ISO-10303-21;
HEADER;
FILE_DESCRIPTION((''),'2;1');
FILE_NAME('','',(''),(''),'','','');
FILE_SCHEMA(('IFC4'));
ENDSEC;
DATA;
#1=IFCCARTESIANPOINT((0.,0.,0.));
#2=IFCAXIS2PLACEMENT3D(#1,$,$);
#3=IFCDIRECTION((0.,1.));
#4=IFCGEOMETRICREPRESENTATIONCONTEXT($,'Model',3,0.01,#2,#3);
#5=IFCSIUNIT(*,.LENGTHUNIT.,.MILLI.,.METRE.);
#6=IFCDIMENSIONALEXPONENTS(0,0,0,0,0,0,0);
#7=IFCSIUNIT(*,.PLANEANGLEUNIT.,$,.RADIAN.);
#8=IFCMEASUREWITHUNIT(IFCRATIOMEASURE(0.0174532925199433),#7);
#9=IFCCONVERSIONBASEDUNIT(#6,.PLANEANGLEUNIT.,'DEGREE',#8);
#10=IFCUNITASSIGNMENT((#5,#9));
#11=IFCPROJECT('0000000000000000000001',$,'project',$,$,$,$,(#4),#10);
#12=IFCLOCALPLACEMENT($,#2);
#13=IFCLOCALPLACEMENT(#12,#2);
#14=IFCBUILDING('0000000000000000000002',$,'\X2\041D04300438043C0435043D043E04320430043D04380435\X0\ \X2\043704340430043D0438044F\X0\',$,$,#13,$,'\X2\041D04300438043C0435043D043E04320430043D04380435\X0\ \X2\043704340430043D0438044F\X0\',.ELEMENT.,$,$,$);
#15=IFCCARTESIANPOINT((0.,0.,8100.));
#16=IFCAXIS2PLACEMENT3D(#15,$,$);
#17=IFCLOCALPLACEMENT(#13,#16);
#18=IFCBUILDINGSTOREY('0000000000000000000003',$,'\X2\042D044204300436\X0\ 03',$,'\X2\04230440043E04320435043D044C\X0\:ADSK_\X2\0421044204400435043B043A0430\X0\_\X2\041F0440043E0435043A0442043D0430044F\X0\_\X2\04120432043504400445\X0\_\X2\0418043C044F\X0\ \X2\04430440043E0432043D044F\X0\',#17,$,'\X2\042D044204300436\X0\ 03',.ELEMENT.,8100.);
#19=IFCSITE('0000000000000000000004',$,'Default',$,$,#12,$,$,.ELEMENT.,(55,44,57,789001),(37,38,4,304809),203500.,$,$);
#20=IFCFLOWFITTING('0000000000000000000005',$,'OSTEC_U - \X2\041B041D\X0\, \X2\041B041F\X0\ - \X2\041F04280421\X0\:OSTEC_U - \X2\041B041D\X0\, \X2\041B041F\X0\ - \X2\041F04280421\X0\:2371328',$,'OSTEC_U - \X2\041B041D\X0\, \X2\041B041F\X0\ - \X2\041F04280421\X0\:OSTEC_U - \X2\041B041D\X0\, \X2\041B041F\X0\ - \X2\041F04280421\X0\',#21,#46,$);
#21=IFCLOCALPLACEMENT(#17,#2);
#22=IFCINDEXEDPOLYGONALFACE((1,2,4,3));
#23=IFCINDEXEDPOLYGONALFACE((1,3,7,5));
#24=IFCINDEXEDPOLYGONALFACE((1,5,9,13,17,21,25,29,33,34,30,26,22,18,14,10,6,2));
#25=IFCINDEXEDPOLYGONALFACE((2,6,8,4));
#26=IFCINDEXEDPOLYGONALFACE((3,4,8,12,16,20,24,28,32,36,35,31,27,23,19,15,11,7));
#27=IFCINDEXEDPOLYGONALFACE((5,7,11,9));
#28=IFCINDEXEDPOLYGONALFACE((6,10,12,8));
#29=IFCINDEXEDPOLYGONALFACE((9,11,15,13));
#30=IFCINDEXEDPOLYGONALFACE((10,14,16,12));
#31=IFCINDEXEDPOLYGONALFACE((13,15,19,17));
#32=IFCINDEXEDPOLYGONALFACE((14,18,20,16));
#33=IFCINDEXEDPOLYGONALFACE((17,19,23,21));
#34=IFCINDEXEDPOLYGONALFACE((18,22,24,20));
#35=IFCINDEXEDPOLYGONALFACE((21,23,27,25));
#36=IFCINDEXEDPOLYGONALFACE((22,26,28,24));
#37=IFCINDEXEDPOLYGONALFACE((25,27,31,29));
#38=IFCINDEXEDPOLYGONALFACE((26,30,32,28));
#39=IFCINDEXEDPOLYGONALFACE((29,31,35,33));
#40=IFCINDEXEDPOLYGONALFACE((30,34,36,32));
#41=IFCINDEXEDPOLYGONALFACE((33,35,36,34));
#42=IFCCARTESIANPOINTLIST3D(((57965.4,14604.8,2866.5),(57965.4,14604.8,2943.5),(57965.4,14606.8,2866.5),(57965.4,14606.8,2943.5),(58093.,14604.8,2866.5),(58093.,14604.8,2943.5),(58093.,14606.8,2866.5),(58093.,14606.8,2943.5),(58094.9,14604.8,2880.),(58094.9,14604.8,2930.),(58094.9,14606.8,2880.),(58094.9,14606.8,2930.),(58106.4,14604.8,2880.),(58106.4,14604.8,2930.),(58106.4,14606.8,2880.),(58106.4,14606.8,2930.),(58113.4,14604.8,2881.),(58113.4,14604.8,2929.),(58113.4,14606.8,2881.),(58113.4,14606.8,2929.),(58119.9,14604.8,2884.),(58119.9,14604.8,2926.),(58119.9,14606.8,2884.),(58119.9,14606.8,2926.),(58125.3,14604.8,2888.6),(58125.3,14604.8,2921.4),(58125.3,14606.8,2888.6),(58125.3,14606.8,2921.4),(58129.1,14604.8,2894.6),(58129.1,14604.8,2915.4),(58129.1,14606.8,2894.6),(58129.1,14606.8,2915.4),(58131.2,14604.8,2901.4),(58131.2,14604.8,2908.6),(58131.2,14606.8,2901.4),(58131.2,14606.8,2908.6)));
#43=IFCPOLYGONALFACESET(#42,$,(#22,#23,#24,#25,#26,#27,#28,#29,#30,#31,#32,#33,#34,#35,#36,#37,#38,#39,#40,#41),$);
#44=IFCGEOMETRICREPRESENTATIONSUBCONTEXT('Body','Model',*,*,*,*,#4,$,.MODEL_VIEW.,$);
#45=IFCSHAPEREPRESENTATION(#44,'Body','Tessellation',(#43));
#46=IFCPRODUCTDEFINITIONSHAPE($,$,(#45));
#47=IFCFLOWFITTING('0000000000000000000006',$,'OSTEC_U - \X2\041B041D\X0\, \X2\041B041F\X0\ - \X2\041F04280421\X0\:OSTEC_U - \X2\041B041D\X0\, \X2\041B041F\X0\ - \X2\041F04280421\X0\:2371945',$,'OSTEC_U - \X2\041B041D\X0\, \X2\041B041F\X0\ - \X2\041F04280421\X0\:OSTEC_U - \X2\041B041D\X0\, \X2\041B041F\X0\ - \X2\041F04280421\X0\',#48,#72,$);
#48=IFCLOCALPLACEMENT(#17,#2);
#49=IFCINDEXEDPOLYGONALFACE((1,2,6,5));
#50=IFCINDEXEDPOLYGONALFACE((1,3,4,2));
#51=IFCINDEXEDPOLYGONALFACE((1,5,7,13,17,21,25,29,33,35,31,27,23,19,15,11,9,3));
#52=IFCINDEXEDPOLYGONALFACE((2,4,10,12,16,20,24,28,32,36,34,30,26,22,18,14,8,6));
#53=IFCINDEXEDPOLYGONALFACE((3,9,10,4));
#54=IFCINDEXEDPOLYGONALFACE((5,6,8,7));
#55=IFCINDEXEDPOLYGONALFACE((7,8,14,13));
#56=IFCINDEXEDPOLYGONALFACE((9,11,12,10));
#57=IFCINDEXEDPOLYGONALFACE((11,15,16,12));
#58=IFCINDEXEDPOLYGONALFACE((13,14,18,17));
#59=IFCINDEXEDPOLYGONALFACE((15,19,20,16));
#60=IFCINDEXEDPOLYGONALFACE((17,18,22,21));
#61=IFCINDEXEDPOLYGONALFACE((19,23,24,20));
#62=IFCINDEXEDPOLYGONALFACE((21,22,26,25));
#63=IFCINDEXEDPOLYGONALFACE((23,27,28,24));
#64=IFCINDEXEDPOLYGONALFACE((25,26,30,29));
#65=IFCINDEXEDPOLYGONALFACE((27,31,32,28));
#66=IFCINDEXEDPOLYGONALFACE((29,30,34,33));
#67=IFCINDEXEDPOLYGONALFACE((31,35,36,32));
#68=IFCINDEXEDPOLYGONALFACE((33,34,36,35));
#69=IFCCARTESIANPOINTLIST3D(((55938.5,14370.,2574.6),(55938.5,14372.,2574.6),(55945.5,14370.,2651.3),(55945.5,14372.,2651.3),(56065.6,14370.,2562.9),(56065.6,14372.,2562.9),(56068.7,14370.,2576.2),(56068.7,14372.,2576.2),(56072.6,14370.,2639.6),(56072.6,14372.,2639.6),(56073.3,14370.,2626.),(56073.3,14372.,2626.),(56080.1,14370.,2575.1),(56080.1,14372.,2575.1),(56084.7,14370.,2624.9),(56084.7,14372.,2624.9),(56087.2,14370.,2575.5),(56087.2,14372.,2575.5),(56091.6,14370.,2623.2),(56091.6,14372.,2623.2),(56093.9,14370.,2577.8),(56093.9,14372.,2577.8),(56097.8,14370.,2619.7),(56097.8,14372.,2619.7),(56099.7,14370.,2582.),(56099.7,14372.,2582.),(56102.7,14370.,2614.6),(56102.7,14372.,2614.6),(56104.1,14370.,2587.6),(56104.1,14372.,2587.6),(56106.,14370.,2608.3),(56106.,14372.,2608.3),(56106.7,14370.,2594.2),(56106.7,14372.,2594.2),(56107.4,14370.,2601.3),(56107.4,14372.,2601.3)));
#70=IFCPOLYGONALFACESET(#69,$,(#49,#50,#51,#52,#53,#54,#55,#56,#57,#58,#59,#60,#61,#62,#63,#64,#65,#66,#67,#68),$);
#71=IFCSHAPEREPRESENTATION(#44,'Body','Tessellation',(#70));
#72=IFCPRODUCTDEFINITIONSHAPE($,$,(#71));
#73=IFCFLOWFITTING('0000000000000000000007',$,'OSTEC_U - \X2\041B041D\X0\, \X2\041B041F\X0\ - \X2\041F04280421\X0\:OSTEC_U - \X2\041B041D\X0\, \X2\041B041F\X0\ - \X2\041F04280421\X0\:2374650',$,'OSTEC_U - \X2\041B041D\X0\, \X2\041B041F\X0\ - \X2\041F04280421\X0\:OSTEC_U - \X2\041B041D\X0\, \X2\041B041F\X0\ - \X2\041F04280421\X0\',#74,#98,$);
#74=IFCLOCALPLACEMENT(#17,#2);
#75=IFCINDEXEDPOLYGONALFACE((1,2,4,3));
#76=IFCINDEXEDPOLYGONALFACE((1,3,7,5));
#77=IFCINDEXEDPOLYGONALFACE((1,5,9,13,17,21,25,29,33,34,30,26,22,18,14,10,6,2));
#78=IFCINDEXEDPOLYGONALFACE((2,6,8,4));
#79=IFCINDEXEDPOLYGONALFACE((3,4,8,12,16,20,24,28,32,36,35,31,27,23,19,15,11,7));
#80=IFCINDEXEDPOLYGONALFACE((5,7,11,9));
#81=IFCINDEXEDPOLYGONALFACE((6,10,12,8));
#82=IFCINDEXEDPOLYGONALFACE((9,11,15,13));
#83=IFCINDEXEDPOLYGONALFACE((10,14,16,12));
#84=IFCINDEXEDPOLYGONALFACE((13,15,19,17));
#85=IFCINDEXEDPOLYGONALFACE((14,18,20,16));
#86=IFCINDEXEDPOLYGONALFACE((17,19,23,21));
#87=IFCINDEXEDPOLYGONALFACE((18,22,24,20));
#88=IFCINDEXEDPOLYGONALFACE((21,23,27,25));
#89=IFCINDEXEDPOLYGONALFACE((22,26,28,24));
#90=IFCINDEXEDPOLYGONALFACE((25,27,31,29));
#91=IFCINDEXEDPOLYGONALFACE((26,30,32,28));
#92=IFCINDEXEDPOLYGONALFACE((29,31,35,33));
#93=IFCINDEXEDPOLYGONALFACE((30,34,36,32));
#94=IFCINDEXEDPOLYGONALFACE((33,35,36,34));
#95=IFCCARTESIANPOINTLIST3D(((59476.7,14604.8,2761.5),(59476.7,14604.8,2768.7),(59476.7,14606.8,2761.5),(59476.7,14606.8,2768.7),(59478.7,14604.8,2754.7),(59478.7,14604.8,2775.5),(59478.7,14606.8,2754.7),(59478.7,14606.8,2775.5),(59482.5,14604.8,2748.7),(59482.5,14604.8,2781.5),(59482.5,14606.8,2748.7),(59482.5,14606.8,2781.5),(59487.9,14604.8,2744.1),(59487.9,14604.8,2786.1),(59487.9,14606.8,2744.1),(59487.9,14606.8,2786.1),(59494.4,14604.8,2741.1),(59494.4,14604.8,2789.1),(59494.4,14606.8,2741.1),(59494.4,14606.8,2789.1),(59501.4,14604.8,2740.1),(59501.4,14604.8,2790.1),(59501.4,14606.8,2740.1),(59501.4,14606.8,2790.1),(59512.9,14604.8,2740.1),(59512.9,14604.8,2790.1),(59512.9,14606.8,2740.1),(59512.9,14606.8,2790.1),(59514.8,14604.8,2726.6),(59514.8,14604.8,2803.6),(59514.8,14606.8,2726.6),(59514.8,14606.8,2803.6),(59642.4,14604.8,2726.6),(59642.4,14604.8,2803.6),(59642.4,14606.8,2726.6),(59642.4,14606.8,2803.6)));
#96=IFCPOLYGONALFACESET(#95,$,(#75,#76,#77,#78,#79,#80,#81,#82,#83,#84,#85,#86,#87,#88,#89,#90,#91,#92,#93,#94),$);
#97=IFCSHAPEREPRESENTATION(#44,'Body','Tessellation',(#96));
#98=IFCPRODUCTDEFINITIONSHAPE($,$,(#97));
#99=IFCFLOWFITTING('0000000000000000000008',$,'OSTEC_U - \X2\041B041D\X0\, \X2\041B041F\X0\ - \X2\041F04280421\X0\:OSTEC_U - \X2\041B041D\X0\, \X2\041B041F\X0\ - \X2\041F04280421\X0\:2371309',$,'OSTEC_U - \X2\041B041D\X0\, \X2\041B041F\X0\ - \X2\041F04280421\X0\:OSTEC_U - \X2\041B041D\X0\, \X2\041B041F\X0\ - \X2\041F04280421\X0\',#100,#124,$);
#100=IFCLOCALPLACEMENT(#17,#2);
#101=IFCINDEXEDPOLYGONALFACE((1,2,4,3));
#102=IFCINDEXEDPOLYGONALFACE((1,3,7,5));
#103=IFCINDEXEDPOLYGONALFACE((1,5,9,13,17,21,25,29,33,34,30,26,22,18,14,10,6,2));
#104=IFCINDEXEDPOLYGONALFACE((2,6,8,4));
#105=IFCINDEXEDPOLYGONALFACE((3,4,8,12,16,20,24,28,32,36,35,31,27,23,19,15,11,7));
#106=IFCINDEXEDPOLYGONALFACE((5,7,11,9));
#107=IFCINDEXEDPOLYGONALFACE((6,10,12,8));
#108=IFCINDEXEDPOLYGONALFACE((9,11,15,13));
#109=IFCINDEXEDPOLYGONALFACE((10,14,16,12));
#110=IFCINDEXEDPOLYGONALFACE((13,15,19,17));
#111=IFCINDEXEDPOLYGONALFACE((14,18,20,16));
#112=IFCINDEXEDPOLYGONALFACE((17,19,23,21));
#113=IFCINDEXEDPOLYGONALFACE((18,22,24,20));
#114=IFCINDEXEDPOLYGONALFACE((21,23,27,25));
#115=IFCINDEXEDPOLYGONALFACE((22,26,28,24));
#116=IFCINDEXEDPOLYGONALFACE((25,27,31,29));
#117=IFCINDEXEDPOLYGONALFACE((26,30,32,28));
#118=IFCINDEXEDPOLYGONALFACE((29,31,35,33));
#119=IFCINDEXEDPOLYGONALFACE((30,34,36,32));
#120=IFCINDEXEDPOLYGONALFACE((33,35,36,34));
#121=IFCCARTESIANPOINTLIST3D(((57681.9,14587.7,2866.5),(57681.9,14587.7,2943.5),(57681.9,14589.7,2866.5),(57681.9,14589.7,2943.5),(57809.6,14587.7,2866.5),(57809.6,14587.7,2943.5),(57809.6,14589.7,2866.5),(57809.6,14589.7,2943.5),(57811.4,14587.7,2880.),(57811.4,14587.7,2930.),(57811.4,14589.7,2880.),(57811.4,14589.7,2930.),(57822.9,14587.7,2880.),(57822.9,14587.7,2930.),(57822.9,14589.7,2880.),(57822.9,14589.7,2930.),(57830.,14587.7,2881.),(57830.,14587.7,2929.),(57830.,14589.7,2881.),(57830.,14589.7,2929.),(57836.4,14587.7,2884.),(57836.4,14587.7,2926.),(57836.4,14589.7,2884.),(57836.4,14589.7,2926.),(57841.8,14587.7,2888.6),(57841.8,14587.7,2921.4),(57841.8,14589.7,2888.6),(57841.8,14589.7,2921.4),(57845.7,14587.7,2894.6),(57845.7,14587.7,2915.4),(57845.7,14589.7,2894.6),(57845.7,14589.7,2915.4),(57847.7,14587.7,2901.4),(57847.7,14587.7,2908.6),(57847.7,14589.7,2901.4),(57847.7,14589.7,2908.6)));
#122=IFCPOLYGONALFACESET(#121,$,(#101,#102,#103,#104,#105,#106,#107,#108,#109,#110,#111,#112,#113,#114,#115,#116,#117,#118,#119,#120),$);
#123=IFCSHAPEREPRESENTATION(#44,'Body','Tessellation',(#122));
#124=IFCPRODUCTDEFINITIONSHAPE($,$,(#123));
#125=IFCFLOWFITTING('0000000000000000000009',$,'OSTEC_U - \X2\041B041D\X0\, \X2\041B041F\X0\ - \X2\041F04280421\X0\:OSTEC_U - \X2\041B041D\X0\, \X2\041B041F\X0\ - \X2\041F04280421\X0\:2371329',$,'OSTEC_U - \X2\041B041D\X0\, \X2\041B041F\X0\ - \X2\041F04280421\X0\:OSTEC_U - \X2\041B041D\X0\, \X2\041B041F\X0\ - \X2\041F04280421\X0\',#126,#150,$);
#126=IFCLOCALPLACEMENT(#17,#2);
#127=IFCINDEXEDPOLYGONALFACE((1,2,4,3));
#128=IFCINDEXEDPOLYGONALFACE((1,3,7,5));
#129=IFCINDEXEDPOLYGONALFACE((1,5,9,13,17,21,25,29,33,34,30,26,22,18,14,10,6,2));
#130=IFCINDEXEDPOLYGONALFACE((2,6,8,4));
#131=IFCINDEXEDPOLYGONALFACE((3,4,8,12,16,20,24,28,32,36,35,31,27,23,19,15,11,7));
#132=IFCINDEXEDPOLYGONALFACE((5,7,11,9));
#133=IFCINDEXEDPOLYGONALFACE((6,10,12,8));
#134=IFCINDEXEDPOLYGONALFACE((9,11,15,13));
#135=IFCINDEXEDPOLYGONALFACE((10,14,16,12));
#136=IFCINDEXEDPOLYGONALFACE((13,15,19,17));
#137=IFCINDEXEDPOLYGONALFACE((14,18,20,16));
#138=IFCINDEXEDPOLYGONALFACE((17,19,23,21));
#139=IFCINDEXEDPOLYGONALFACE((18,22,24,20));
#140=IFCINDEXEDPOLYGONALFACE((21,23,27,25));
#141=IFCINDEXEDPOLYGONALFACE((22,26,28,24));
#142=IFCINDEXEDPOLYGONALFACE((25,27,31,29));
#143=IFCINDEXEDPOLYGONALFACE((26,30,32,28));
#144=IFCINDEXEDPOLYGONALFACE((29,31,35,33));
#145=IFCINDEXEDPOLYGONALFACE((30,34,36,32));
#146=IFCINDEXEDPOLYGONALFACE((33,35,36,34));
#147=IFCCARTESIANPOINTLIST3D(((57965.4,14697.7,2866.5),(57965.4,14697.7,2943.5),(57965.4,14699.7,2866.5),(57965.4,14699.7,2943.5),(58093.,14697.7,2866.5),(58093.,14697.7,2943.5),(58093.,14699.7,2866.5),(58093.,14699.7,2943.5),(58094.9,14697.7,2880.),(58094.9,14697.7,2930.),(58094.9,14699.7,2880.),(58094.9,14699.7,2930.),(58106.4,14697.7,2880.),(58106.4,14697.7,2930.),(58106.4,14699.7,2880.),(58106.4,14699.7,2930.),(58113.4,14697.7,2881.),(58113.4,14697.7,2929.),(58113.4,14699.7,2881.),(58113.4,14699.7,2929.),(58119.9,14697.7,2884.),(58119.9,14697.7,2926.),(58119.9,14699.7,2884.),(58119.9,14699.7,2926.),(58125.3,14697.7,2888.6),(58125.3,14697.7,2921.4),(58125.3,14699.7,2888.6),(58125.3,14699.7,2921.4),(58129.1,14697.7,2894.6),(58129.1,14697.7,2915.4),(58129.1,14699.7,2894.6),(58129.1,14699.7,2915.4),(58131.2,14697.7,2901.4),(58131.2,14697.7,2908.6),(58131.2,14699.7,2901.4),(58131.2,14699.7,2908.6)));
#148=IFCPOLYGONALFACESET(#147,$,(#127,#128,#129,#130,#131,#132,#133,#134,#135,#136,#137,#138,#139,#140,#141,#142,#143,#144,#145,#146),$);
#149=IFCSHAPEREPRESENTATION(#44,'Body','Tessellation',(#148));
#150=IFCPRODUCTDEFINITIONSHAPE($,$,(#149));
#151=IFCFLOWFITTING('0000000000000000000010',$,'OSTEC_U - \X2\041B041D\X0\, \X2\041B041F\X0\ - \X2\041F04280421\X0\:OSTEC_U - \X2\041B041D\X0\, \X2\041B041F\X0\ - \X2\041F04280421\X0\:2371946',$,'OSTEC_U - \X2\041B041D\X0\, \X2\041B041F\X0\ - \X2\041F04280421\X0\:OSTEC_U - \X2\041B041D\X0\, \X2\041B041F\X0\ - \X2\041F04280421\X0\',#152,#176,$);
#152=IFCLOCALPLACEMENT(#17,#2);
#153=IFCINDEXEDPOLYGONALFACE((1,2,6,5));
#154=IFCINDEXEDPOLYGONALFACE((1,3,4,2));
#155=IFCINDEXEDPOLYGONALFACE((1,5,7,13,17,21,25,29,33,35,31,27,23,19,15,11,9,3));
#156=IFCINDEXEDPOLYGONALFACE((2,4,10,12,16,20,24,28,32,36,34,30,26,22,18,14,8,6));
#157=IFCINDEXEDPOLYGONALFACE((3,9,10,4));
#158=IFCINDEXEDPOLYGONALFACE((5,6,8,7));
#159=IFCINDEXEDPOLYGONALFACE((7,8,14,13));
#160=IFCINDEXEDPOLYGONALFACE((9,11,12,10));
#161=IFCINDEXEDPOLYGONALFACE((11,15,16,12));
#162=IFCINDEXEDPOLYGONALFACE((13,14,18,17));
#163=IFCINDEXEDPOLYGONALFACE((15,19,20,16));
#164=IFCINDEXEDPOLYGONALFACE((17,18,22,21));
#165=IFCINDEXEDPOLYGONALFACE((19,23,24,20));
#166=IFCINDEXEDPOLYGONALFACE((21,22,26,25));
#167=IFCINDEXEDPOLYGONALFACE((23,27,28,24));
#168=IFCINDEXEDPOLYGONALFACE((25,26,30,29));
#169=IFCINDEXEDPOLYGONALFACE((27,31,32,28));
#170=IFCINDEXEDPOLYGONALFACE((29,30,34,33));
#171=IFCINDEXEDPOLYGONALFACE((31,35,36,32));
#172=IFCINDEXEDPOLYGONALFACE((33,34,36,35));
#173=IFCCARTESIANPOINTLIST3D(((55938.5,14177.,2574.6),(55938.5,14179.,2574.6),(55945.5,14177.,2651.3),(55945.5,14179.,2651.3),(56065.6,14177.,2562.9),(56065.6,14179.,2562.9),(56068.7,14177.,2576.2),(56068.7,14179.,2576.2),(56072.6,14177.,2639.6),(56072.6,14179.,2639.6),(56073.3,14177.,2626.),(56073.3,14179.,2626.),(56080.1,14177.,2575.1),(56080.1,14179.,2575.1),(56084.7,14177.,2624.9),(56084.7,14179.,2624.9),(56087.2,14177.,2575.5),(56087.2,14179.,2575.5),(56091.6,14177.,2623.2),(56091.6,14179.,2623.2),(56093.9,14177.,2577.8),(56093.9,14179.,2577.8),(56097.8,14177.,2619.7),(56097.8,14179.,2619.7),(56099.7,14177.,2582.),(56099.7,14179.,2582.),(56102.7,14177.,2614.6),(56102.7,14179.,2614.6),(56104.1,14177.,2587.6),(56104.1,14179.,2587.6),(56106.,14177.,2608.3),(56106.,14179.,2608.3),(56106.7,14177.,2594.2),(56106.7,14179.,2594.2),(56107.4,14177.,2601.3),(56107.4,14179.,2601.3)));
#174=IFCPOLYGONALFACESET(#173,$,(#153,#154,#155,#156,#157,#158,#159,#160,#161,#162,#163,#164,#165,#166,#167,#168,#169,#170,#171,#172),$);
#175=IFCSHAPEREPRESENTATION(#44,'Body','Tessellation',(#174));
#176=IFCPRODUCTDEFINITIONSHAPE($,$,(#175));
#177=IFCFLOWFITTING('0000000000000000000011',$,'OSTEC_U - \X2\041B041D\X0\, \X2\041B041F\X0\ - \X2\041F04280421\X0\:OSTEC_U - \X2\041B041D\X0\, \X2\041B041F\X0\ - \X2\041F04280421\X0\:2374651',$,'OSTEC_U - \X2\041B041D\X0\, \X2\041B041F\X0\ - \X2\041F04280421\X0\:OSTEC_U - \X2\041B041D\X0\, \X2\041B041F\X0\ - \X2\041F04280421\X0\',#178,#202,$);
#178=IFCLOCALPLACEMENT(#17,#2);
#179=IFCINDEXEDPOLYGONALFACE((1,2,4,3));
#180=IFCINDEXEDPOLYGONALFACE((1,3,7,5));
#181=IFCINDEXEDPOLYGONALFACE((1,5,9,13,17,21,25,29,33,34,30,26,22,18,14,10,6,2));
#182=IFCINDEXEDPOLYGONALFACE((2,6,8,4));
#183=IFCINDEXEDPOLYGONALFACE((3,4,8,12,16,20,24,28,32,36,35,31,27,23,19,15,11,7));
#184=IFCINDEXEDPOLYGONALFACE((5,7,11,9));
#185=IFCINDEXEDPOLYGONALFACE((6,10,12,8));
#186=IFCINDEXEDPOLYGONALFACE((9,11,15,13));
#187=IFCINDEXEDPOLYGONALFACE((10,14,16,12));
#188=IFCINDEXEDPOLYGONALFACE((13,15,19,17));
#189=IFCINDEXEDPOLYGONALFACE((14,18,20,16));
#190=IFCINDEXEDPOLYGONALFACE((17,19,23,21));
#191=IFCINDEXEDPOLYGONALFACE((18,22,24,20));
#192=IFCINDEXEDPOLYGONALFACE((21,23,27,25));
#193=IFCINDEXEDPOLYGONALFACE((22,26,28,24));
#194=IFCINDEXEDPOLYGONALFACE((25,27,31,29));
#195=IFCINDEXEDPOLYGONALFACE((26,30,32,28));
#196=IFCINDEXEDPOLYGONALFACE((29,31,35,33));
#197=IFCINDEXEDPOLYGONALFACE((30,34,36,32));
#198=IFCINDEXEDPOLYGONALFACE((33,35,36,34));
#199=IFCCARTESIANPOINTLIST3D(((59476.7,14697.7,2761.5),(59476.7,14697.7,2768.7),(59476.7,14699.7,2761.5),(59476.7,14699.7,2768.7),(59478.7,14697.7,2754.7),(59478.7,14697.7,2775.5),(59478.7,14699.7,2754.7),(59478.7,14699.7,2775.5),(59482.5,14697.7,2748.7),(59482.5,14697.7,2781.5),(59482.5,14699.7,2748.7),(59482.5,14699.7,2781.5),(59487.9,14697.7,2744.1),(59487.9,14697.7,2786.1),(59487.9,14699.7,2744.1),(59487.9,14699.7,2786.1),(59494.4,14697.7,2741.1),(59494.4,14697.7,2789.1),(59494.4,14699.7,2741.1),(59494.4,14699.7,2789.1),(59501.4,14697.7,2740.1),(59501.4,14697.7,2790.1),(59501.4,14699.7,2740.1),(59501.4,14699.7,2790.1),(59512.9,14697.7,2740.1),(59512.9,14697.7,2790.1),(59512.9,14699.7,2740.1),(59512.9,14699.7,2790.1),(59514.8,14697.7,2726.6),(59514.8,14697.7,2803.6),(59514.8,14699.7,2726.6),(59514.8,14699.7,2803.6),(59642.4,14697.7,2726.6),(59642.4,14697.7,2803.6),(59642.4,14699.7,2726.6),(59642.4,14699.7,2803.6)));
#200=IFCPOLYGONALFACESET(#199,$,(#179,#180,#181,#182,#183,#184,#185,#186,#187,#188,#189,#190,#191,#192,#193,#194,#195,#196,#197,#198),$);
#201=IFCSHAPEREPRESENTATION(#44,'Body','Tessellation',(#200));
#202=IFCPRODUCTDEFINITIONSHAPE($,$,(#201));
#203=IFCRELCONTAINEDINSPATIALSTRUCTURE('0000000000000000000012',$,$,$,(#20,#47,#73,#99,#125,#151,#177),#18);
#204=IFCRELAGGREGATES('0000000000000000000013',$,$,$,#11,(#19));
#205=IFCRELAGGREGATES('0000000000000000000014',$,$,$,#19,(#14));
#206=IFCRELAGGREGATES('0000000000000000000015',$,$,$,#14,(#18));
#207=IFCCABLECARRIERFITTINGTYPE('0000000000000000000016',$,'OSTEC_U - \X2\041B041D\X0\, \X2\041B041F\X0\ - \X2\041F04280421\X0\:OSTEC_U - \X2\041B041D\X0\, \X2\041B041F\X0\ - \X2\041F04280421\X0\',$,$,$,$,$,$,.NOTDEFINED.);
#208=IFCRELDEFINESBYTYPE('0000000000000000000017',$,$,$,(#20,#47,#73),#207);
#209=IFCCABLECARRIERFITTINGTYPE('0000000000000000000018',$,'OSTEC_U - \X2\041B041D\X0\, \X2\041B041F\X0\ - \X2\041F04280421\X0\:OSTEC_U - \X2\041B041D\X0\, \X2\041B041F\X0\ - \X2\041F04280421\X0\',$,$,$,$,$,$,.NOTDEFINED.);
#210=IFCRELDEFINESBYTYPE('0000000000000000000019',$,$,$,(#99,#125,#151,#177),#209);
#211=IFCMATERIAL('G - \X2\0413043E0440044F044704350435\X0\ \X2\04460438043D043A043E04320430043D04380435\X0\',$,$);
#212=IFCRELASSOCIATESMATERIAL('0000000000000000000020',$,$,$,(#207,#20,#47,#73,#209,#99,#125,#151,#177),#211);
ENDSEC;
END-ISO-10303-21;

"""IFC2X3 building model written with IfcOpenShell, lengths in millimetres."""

from ifc_helpers import new_model, entity, si_unit, converted_unit, direction, frame, frame_2d, origin, place, context, subcontext, project, spatial, polyline, circle_curve, parameter, trimmed, segment, composite_curve, outline, extrude, source, transform, mapped, material, type_object, type_shapes, element, save


model = new_model("IFC2X3")

# Units and contexts
model_context = context("Model", 3, precision=0.01, world=origin(), true_north=direction((0.0, 1.0)))
body_context = subcontext(model_context, "Body", "Model", "MODEL_VIEW")
ifc_project = project(units=[si_unit("LENGTHUNIT", "METRE", prefix="MILLI"), converted_unit("PLANEANGLEUNIT", "DEGREE", entity("IfcRatioMeasure", 0.0174532925199433), si_unit("PLANEANGLEUNIT", "RADIAN"), dimensions=[0, 0, 0, 0, 0, 0, 0])], contexts=[model_context])

# Site, building, storey
site_placement = place(None, frame((0.0, 0.0, 0.0)))
site = spatial("IfcSite", under=ifc_project, at=site_placement, Name="Default", CompositionType="ELEMENT", RefLatitude=(55, 44, 57, 789001), RefLongitude=(37, 38, 4, 304809), RefElevation=203500.0)
building_placement = place(site_placement, origin())
building = spatial("IfcBuilding", under=site, at=building_placement, Name="Наименование здания", LongName="Наименование здания", CompositionType="ELEMENT")
storey_placement = place(building_placement, frame((0.0, 0.0, 8100.0)))
storey = spatial("IfcBuildingStorey", under=building, at=storey_placement, Name="Этаж 03", ObjectType="Уровень:ADSK_Стрелка_Проектная_Вверх_Имя уровня", LongName="Этаж 03", CompositionType="ELEMENT", Elevation=8100.0)

# Flow fittings
ifc_material = material(Name="G - Горячее цинкование")
cable_carrier_fitting_type_1 = type_object("IfcCableCarrierFittingType", Name="OSTEC_U - ЛН, ЛП - ПШС:OSTEC_U - ЛН, ЛП - ПШС", PredefinedType="NOTDEFINED", material=ifc_material)
shared_shape_1 = source(origin(), body_context, "Body", "SweptSolid", [
    extrude(outline(composite_curve([segment(trimmed(circle_curve(frame_2d((-41.5, 0.0), x_axis=(1.0, 0.0)), 25.0), [parameter(90.0)], [parameter(270.0)], True, "PARAMETER"), True, "CONTINUOUS"), segment(polyline([(-41.5, -25.0), (-30.0, -25.0)]), True, "CONTINUOUS"), segment(polyline([(-30.0, -25.0), (-28.1, -38.5)]), True, "CONTINUOUS"), segment(polyline([(-28.1, -38.5), (99.5, -38.5)]), True, "CONTINUOUS"), segment(polyline([(99.5, -38.5), (99.5, 38.5)]), True, "CONTINUOUS"), segment(polyline([(99.5, 38.5), (-28.1, 38.5)]), True, "CONTINUOUS"), segment(polyline([(-28.1, 38.5), (-30.0, 25.0)]), True, "CONTINUOUS"), segment(polyline([(-30.0, 25.0), (-41.5, 25.0)]), True, "CONTINUOUS")], self_intersect=False)), frame((41.5, 0.0, 0.0), z_axis=(0.0, 0.0, -1.0), x_axis=(1.0, 0.0, 0.0)), (0.0, 0.0, -1.0), 2.0),
])
type_shapes(cable_carrier_fitting_type_1, [shared_shape_1])
for number, where, z_axis, x_axis, name in (
    (1, (58106.4, 14606.8, 2905.0), (0.0, -1.0, 0.0), (-1.0, 0.0, 0.0), "OSTEC_U - ЛН, ЛП - ПШС:OSTEC_U - ЛН, ЛП - ПШС:2371328"),
    (2, (56082.4, 14370.0, 2600.0), (0.0, 1.0, 0.0), (-0.995778, 0.0, 0.09179), "OSTEC_U - ЛН, ЛП - ПШС:OSTEC_U - ЛН, ЛП - ПШС:2371945"),
    (3, (59501.4, 14606.8, 2765.1), (0.0, -1.0, 0.0), (1.0, 0.0, 0.0), "OSTEC_U - ЛН, ЛП - ПШС:OSTEC_U - ЛН, ЛП - ПШС:2374650"),
):
    element("IfcFlowFitting", number, at=place(storey_placement, frame(where, z_axis=z_axis, x_axis=x_axis)), inside=storey, type_object=cable_carrier_fitting_type_1, material=ifc_material, Name=name, ObjectType="OSTEC_U - ЛН, ЛП - ПШС:OSTEC_U - ЛН, ЛП - ПШС", context=body_context, shape_type="MappedRepresentation", body=[
        mapped(shared_shape_1, transform((0.0, 0.0, 0.0), scale=1.0)),
    ])
cable_carrier_fitting_type_2 = type_object("IfcCableCarrierFittingType", Name="OSTEC_U - ЛН, ЛП - ПШС:OSTEC_U - ЛН, ЛП - ПШС", PredefinedType="NOTDEFINED", material=ifc_material)
shared_shape_2 = source(origin(), body_context, "Body", "SweptSolid", [
    extrude(outline(composite_curve([segment(trimmed(circle_curve(frame_2d((-41.5, 0.0), x_axis=(1.0, 0.0)), 25.0), [parameter(90.0)], [parameter(270.0)], True, "PARAMETER"), True, "CONTINUOUS"), segment(polyline([(-41.5, -25.0), (-30.0, -25.0)]), True, "CONTINUOUS"), segment(polyline([(-30.0, -25.0), (-28.1, -38.5)]), True, "CONTINUOUS"), segment(polyline([(-28.1, -38.5), (99.5, -38.5)]), True, "CONTINUOUS"), segment(polyline([(99.5, -38.5), (99.5, 38.5)]), True, "CONTINUOUS"), segment(polyline([(99.5, 38.5), (-28.1, 38.5)]), True, "CONTINUOUS"), segment(polyline([(-28.1, 38.5), (-30.0, 25.0)]), True, "CONTINUOUS"), segment(polyline([(-30.0, 25.0), (-41.5, 25.0)]), True, "CONTINUOUS")], self_intersect=False)), frame((41.5, 0.0, 0.0)), (0.0, 0.0, 1.0), 2.0),
])
type_shapes(cable_carrier_fitting_type_2, [shared_shape_2])
for number, where, z_axis, x_axis, name in (
    (4, (57822.9, 14587.7, 2905.0), (0.0, 1.0, 0.0), (-1.0, 0.0, 0.0), "OSTEC_U - ЛН, ЛП - ПШС:OSTEC_U - ЛН, ЛП - ПШС:2371309"),
    (5, (58106.4, 14697.7, 2905.0), (0.0, 1.0, 0.0), (-1.0, 0.0, 0.0), "OSTEC_U - ЛН, ЛП - ПШС:OSTEC_U - ЛН, ЛП - ПШС:2371329"),
    (6, (56082.4, 14179.0, 2600.0), (0.0, -1.0, 0.0), (-0.995778, 0.0, 0.09179), "OSTEC_U - ЛН, ЛП - ПШС:OSTEC_U - ЛН, ЛП - ПШС:2371946"),
    (7, (59501.4, 14697.7, 2765.1), (0.0, 1.0, 0.0), (1.0, 0.0, 0.0), "OSTEC_U - ЛН, ЛП - ПШС:OSTEC_U - ЛН, ЛП - ПШС:2374651"),
):
    element("IfcFlowFitting", number, at=place(storey_placement, frame(where, z_axis=z_axis, x_axis=x_axis)), inside=storey, type_object=cable_carrier_fitting_type_2, material=ifc_material, Name=name, ObjectType="OSTEC_U - ЛН, ЛП - ПШС:OSTEC_U - ЛН, ЛП - ПШС", context=body_context, shape_type="MappedRepresentation", body=[
        mapped(shared_shape_2, transform((0.0, 0.0, 0.0), scale=1.0)),
    ])

save(model, "model.ifc")
